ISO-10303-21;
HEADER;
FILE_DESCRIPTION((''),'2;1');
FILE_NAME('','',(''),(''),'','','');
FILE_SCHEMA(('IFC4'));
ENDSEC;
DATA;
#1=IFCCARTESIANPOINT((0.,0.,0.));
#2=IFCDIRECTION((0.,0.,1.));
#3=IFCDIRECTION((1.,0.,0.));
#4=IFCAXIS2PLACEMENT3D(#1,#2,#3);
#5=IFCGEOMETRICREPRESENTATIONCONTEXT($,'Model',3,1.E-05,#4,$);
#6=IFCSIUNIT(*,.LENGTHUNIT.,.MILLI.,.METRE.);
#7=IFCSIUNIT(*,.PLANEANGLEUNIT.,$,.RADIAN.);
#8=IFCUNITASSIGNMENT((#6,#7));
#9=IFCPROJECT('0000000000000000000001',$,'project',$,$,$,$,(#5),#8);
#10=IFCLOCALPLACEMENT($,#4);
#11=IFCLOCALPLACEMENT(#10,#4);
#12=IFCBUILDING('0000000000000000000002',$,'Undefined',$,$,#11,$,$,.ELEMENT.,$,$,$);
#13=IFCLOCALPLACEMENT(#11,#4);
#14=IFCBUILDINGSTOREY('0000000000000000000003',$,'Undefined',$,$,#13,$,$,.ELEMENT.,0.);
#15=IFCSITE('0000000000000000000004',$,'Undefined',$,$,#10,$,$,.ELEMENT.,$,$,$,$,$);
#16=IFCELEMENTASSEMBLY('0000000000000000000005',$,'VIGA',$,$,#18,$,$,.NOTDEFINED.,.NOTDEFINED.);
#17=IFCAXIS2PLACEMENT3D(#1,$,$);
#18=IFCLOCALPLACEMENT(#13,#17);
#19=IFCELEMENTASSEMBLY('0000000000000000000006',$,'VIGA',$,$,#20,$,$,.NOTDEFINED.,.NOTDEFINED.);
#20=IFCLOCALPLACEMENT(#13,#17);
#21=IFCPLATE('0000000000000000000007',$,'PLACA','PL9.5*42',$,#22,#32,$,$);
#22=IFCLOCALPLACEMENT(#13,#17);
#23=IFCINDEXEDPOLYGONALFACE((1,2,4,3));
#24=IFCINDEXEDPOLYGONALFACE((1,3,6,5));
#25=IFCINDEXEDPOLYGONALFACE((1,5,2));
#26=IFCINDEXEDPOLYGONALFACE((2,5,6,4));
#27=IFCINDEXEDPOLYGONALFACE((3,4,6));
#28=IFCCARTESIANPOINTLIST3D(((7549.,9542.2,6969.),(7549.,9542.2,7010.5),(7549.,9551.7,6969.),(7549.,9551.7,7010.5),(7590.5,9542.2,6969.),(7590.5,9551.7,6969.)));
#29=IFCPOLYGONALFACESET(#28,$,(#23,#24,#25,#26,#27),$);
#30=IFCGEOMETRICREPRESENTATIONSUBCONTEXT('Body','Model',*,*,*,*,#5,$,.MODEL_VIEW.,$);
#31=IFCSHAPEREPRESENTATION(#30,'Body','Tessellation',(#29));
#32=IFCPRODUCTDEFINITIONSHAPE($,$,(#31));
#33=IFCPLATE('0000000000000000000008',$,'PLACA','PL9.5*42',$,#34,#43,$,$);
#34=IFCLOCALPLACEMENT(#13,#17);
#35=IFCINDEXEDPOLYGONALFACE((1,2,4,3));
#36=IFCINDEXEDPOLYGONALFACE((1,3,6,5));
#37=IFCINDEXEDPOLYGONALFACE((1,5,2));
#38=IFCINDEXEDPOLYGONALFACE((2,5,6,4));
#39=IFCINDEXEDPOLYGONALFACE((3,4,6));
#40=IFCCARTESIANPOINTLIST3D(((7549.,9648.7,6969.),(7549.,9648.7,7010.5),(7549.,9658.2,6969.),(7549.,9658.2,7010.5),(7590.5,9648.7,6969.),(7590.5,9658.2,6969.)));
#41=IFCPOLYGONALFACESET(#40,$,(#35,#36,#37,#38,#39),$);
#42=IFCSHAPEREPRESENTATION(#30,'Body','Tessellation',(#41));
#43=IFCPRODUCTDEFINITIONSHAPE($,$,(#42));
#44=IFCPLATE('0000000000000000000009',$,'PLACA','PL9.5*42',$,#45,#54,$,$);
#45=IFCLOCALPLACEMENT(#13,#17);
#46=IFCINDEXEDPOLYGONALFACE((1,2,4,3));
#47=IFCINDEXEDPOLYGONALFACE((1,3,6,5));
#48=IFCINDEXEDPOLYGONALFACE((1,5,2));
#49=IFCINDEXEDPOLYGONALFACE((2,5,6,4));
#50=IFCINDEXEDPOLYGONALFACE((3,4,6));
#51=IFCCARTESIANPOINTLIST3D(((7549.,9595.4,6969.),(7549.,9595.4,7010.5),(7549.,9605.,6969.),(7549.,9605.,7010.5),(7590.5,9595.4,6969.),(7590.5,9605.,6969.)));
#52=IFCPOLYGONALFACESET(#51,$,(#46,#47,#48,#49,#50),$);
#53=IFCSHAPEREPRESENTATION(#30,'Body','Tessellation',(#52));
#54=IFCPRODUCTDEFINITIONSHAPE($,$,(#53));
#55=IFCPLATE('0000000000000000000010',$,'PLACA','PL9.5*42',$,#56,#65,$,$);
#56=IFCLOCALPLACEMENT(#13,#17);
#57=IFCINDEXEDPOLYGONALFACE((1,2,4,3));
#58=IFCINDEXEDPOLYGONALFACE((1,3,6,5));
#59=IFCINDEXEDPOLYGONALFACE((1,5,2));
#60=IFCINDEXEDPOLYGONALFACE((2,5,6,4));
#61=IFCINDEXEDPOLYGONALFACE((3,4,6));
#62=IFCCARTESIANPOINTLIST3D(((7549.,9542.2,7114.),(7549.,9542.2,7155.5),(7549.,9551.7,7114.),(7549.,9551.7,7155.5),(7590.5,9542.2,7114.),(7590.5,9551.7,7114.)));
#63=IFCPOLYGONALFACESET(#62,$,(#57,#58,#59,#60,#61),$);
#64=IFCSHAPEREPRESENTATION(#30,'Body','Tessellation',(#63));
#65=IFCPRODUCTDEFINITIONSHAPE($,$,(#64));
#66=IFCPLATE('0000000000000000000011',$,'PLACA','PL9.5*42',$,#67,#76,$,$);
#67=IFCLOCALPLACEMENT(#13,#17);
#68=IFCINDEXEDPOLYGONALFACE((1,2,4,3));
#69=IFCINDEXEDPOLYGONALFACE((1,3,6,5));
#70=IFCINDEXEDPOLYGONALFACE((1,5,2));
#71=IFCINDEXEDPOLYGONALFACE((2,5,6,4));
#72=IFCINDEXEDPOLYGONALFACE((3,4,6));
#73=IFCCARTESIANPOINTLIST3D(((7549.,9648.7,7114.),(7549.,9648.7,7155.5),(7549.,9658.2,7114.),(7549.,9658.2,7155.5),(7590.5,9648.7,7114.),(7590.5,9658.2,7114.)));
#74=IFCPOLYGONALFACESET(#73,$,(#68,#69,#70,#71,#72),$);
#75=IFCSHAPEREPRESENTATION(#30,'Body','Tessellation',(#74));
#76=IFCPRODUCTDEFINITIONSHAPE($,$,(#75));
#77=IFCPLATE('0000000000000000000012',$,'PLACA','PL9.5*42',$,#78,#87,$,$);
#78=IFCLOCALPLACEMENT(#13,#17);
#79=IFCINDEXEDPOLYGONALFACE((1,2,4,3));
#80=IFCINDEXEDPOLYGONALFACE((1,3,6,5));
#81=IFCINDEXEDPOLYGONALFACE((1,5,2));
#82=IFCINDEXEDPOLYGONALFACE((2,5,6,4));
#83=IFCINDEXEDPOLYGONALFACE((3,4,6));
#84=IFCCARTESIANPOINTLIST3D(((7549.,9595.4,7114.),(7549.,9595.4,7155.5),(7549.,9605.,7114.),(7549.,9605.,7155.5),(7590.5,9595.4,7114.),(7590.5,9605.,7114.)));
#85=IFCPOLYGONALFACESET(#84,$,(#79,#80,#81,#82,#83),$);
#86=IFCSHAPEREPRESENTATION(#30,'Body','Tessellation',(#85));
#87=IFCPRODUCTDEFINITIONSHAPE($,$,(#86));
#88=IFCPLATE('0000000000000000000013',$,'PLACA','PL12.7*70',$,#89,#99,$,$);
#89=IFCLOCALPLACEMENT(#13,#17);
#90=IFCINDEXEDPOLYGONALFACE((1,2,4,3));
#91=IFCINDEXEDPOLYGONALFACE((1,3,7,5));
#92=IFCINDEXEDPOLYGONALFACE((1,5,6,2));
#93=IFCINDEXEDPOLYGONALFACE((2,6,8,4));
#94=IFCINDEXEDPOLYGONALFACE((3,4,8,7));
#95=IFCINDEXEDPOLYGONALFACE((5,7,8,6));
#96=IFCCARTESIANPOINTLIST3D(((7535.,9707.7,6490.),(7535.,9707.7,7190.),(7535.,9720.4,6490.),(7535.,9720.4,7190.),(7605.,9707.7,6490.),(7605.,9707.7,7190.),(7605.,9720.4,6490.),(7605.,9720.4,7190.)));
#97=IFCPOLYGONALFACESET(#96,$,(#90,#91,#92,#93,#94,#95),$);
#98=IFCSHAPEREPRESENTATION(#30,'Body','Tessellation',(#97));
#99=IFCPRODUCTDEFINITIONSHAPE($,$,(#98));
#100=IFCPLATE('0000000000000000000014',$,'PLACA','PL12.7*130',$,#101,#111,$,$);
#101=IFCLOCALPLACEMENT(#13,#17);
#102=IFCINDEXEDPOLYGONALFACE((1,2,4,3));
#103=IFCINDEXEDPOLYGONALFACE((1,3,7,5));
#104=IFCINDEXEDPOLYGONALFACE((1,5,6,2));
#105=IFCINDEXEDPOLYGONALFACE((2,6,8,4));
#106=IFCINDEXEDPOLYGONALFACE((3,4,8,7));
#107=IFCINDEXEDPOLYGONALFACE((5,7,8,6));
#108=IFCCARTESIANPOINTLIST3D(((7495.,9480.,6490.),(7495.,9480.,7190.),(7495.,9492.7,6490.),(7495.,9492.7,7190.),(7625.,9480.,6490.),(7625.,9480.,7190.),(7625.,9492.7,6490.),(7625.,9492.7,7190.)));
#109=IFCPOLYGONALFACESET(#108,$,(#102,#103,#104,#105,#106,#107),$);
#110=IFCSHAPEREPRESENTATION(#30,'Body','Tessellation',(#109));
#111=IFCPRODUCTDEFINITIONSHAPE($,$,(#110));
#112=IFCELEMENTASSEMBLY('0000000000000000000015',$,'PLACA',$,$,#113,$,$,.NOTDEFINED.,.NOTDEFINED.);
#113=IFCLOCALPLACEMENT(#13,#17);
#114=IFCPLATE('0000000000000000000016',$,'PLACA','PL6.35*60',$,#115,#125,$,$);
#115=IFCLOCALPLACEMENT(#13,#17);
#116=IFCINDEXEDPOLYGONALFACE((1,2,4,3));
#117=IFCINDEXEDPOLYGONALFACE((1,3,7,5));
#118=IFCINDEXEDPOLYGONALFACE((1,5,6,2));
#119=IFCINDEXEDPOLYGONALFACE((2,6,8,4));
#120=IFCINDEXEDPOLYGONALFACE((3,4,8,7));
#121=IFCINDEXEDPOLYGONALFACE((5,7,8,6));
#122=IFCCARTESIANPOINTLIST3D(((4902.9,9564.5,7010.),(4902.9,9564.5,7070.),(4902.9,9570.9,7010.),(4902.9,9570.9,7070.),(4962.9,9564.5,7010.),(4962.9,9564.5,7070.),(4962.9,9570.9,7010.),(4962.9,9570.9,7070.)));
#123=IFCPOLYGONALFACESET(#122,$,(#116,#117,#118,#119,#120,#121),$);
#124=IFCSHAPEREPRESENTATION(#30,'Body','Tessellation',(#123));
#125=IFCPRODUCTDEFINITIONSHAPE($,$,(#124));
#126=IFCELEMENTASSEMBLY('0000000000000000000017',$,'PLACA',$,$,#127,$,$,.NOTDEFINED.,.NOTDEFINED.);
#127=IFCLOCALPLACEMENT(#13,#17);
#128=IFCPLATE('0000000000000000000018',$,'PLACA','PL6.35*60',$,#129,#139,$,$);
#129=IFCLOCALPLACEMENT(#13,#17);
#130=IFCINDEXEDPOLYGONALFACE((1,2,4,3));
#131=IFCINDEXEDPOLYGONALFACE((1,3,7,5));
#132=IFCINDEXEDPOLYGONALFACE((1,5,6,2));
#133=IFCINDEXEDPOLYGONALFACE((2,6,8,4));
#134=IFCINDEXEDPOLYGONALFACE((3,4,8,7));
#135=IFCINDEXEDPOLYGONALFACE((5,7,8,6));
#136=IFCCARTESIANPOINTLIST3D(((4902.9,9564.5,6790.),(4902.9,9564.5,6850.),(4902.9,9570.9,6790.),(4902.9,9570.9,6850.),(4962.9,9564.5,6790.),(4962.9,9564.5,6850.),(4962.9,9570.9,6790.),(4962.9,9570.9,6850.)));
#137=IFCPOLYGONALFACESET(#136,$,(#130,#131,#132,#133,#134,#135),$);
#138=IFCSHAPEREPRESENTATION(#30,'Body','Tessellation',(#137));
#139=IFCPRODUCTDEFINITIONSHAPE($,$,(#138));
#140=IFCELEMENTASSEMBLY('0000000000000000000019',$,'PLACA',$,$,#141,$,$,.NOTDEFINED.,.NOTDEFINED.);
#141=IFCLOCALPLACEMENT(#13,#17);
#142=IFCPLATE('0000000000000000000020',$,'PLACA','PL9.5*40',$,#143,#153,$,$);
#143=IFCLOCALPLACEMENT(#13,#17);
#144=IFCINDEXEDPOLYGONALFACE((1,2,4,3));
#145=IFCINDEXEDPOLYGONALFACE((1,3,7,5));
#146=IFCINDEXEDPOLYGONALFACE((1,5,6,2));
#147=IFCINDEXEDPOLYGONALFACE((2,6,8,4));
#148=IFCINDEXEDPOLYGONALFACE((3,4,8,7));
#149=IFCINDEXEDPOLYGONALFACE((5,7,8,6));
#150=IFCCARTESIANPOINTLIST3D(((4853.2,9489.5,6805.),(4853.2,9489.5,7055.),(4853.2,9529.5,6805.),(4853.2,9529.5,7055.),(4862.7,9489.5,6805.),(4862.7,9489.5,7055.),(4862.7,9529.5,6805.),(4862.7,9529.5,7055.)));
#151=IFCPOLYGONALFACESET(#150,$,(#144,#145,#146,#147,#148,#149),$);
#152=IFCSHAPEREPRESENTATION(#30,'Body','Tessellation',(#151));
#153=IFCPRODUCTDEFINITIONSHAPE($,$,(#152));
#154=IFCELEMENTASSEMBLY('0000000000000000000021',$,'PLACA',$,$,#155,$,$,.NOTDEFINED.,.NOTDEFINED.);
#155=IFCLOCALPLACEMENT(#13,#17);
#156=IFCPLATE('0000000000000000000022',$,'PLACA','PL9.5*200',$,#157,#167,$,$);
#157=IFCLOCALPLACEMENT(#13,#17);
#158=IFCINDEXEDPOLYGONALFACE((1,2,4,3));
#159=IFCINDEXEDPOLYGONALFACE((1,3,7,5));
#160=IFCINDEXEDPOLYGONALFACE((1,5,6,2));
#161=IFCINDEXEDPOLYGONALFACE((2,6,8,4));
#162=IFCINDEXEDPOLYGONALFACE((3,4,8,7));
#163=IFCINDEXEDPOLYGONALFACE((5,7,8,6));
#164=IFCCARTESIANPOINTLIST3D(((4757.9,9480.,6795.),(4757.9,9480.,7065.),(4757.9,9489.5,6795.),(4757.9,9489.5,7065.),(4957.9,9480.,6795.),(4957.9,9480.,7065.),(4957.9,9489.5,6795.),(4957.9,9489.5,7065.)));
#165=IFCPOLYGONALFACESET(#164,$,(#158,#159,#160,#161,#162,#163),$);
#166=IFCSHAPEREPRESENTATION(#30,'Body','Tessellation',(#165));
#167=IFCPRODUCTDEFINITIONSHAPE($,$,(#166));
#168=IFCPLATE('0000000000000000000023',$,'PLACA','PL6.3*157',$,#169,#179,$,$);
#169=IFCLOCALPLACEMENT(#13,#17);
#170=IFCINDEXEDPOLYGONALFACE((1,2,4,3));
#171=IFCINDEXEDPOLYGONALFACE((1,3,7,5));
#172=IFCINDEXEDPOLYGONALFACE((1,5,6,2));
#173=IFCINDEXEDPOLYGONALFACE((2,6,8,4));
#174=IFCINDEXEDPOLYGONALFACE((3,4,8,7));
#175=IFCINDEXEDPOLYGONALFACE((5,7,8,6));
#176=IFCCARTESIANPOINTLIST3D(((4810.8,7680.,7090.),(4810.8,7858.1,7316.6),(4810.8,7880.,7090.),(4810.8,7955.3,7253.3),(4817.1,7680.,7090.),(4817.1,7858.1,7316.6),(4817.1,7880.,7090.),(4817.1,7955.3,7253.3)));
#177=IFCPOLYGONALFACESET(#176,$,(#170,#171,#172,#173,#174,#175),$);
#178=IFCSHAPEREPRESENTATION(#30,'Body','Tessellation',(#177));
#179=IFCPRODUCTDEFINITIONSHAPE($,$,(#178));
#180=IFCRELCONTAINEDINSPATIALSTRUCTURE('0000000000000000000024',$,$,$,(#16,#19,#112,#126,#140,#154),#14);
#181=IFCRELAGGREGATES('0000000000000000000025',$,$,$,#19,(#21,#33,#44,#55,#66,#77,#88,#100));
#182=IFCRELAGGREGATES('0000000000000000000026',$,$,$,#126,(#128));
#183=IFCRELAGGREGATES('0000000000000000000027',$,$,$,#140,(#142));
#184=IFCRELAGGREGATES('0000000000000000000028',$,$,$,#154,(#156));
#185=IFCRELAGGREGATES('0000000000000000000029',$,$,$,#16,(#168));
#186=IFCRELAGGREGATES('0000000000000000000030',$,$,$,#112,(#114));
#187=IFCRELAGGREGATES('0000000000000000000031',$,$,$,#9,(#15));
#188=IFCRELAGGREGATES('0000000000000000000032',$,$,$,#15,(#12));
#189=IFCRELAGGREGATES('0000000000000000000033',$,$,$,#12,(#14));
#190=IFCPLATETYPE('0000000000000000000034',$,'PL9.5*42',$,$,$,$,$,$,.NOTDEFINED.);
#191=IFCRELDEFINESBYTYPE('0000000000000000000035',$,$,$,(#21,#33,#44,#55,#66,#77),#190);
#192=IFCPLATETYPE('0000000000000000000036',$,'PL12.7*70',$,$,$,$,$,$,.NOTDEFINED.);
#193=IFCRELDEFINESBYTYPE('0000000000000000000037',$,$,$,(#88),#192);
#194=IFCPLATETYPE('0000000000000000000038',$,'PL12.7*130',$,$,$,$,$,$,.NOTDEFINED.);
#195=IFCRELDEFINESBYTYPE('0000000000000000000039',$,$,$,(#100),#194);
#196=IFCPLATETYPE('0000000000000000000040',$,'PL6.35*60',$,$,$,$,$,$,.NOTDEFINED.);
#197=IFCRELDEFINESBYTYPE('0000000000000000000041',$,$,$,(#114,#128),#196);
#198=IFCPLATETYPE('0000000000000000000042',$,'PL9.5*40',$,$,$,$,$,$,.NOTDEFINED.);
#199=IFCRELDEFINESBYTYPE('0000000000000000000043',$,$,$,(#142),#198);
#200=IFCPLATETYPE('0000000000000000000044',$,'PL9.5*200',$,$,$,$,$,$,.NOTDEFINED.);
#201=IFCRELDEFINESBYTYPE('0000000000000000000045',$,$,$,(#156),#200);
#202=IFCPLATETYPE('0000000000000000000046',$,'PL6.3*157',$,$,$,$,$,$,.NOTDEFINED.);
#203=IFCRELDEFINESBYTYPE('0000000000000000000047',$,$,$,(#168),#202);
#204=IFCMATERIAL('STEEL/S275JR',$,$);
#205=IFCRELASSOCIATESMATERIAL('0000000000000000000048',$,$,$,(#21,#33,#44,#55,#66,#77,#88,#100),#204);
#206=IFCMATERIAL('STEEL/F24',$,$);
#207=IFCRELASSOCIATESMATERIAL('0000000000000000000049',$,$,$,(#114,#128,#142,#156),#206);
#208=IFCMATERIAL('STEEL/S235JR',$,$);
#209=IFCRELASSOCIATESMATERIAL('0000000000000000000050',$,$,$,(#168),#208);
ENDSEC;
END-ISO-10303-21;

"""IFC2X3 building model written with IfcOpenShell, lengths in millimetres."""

from ifc_helpers import new_model, si_unit, frame, origin_with_axes, place, context, subcontext, project, spatial, polyline, outline, extrude, material, type_object, element, aggregate, save


model = new_model("IFC2X3")

# Units and contexts
model_context = context("Model", 3, precision=1e-05, world=origin_with_axes())
body_context = subcontext(model_context, "Body", "Model", "MODEL_VIEW")
ifc_project = project(units=[si_unit("LENGTHUNIT", "METRE", prefix="MILLI"), si_unit("PLANEANGLEUNIT", "RADIAN")], contexts=[model_context])

# Site, building, storey
site_placement = place(None, origin_with_axes())
site = spatial("IfcSite", under=ifc_project, at=site_placement, Name="Undefined", CompositionType="ELEMENT")
building_placement = place(site_placement, origin_with_axes())
building = spatial("IfcBuilding", under=site, at=building_placement, Name="Undefined", CompositionType="ELEMENT")
storey_placement = place(building_placement, origin_with_axes())
storey = spatial("IfcBuildingStorey", under=building, at=storey_placement, Name="Undefined", CompositionType="ELEMENT", Elevation=0.0)

# Shared definitions
ifc_material_1 = material(Name="STEEL/S275JR")

# Shared definitions
ifc_material_2 = material(Name="STEEL/S235JR")

# Element assemblies, plates
assembly_1_placement = place(storey_placement, origin_with_axes())
assembly_1 = element("IfcElementAssembly", 1, at=assembly_1_placement, inside=storey, Name="VIGA", AssemblyPlace="NOTDEFINED", PredefinedType="NOTDEFINED")
assembly_2_placement = place(storey_placement, origin_with_axes())
assembly_2 = element("IfcElementAssembly", 2, at=assembly_2_placement, inside=storey, Name="VIGA", AssemblyPlace="NOTDEFINED", PredefinedType="NOTDEFINED")
plate_type_1 = type_object("IfcPlateType", Name="PL9.5*42", PredefinedType="NOTDEFINED")
plate_1_placement = place(assembly_2_placement, frame((7549.0, 9547.0, 6969.0), z_axis=(0.0, 1.0, 0.0), x_axis=(0.0, 0.0, 1.0)))
plate_1 = element("IfcPlate", 3, at=plate_1_placement, type_object=plate_type_1, material=ifc_material_1, Name="PLACA", Description="PL9.5*42", context=body_context, shape_type="SweptSolid", body=[
    extrude(outline(polyline([(0.0, 0.0), (41.5, 0.0), (0.0, 41.5), (0.0, 0.0)])), frame((0.0, 0.0, -4.7), z_axis=(0.0, 0.0, 1.0), x_axis=(1.0, 0.0, 0.0)), (0.0, 0.0, 1.0), 9.5),
])
plate_2_placement = place(assembly_2_placement, frame((7549.0, 9653.5, 6969.0), z_axis=(0.0, 1.0, 0.0), x_axis=(0.0, 0.0, 1.0)))
plate_2 = element("IfcPlate", 4, at=plate_2_placement, type_object=plate_type_1, material=ifc_material_1, Name="PLACA", Description="PL9.5*42", context=body_context, shape_type="SweptSolid", body=[
    extrude(outline(polyline([(0.0, 0.0), (41.5, 0.0), (0.0, 41.5), (0.0, 0.0)])), frame((0.0, 0.0, -4.7), z_axis=(0.0, 0.0, 1.0), x_axis=(1.0, 0.0, 0.0)), (0.0, 0.0, 1.0), 9.5),
])
plate_3_placement = place(assembly_2_placement, frame((7549.0, 9600.2, 6969.0), z_axis=(0.0, 1.0, 0.0), x_axis=(0.0, 0.0, 1.0)))
plate_3 = element("IfcPlate", 5, at=plate_3_placement, type_object=plate_type_1, material=ifc_material_1, Name="PLACA", Description="PL9.5*42", context=body_context, shape_type="SweptSolid", body=[
    extrude(outline(polyline([(0.0, 0.0), (41.5, 0.0), (0.0, 41.5), (0.0, 0.0)])), frame((0.0, 0.0, -4.7), z_axis=(0.0, 0.0, 1.0), x_axis=(1.0, 0.0, 0.0)), (0.0, 0.0, 1.0), 9.5),
])
plate_4_placement = place(assembly_2_placement, frame((7549.0, 9547.0, 7114.0), z_axis=(0.0, 1.0, 0.0), x_axis=(0.0, 0.0, 1.0)))
plate_4 = element("IfcPlate", 6, at=plate_4_placement, type_object=plate_type_1, material=ifc_material_1, Name="PLACA", Description="PL9.5*42", context=body_context, shape_type="SweptSolid", body=[
    extrude(outline(polyline([(0.0, 0.0), (41.5, 0.0), (0.0, 41.5), (0.0, 0.0)])), frame((0.0, 0.0, -4.7), z_axis=(0.0, 0.0, 1.0), x_axis=(1.0, 0.0, 0.0)), (0.0, 0.0, 1.0), 9.5),
])
plate_5_placement = place(assembly_2_placement, frame((7549.0, 9653.5, 7114.0), z_axis=(0.0, 1.0, 0.0), x_axis=(0.0, 0.0, 1.0)))
plate_5 = element("IfcPlate", 7, at=plate_5_placement, type_object=plate_type_1, material=ifc_material_1, Name="PLACA", Description="PL9.5*42", context=body_context, shape_type="SweptSolid", body=[
    extrude(outline(polyline([(0.0, 0.0), (41.5, 0.0), (0.0, 41.5), (0.0, 0.0)])), frame((0.0, 0.0, -4.7), z_axis=(0.0, 0.0, 1.0), x_axis=(1.0, 0.0, 0.0)), (0.0, 0.0, 1.0), 9.5),
])
plate_6_placement = place(assembly_2_placement, frame((7549.0, 9600.2, 7114.0), z_axis=(0.0, 1.0, 0.0), x_axis=(0.0, 0.0, 1.0)))
plate_6 = element("IfcPlate", 8, at=plate_6_placement, type_object=plate_type_1, material=ifc_material_1, Name="PLACA", Description="PL9.5*42", context=body_context, shape_type="SweptSolid", body=[
    extrude(outline(polyline([(0.0, 0.0), (41.5, 0.0), (0.0, 41.5), (0.0, 0.0)])), frame((0.0, 0.0, -4.7), z_axis=(0.0, 0.0, 1.0), x_axis=(1.0, 0.0, 0.0)), (0.0, 0.0, 1.0), 9.5),
])
plate_type_2 = type_object("IfcPlateType", Name="PL12.7*70", PredefinedType="NOTDEFINED")
plate_7_placement = place(assembly_2_placement, frame((7535.0, 9714.0, 7190.0), z_axis=(0.0, 1.0, 0.0), x_axis=(1.0, 0.0, 0.0)))
plate_7 = element("IfcPlate", 9, at=plate_7_placement, type_object=plate_type_2, material=ifc_material_1, Name="PLACA", Description="PL12.7*70", context=body_context, shape_type="SweptSolid", body=[
    extrude(outline(polyline([(0.0, 0.0), (70.0, 0.0), (70.0, 700.0), (0.0, 700.0), (0.0, 0.0)])), frame((0.0, 0.0, -6.3), z_axis=(0.0, 0.0, 1.0), x_axis=(1.0, 0.0, 0.0)), (0.0, 0.0, 1.0), 12.7),
])
plate_type_3 = type_object("IfcPlateType", Name="PL12.7*130", PredefinedType="NOTDEFINED")
plate_8_placement = place(assembly_2_placement, frame((7495.0, 9486.3, 7190.0), z_axis=(0.0, 1.0, 0.0), x_axis=(1.0, 0.0, 0.0)))
plate_8 = element("IfcPlate", 10, at=plate_8_placement, type_object=plate_type_3, material=ifc_material_1, Name="PLACA", Description="PL12.7*130", context=body_context, shape_type="SweptSolid", body=[
    extrude(outline(polyline([(0.0, 0.0), (130.0, 0.0), (130.0, 700.0), (0.0, 700.0), (0.0, 0.0)])), frame((0.0, 0.0, -6.3), z_axis=(0.0, 0.0, 1.0), x_axis=(1.0, 0.0, 0.0)), (0.0, 0.0, 1.0), 12.7),
])
aggregate(assembly_2, [plate_1, plate_2, plate_3, plate_4, plate_5, plate_6, plate_7, plate_8])

# Element assemblies, plates
assembly_3_placement = place(storey_placement, origin_with_axes())
assembly_3 = element("IfcElementAssembly", 11, at=assembly_3_placement, inside=storey, Name="PLACA", AssemblyPlace="NOTDEFINED", PredefinedType="NOTDEFINED")
ifc_material_3 = material(Name="STEEL/F24")
plate_type_4 = type_object("IfcPlateType", Name="PL6.35*60", PredefinedType="NOTDEFINED")
plate_9_placement = place(assembly_3_placement, frame((4902.9, 9567.7, 7070.0), z_axis=(0.0, 1.0, 0.0), x_axis=(1.0, 0.0, 0.0)))
plate_9 = element("IfcPlate", 12, at=plate_9_placement, type_object=plate_type_4, material=ifc_material_3, Name="PLACA", Description="PL6.35*60", context=body_context, shape_type="SweptSolid", body=[
    extrude(outline(polyline([(0.0, 0.0), (60.0, 0.0), (60.0, 60.0), (0.0, 60.0), (0.0, 0.0)])), frame((0.0, 0.0, -3.2), z_axis=(0.0, 0.0, 1.0), x_axis=(1.0, 0.0, 0.0)), (0.0, 0.0, 1.0), 6.4),
])
assembly_4_placement = place(storey_placement, origin_with_axes())
assembly_4 = element("IfcElementAssembly", 13, at=assembly_4_placement, inside=storey, Name="PLACA", AssemblyPlace="NOTDEFINED", PredefinedType="NOTDEFINED")
plate_10_placement = place(assembly_4_placement, frame((4902.9, 9567.7, 6850.0), z_axis=(0.0, 1.0, 0.0), x_axis=(1.0, 0.0, 0.0)))
plate_10 = element("IfcPlate", 14, at=plate_10_placement, type_object=plate_type_4, material=ifc_material_3, Name="PLACA", Description="PL6.35*60", context=body_context, shape_type="SweptSolid", body=[
    extrude(outline(polyline([(0.0, 0.0), (60.0, 0.0), (60.0, 60.0), (0.0, 60.0), (0.0, 0.0)])), frame((0.0, 0.0, -3.2), z_axis=(0.0, 0.0, 1.0), x_axis=(1.0, 0.0, 0.0)), (0.0, 0.0, 1.0), 6.4),
])
aggregate(assembly_4, [plate_10])
assembly_5_placement = place(storey_placement, origin_with_axes())
assembly_5 = element("IfcElementAssembly", 15, at=assembly_5_placement, inside=storey, Name="PLACA", AssemblyPlace="NOTDEFINED", PredefinedType="NOTDEFINED")
plate_type_5 = type_object("IfcPlateType", Name="PL9.5*40", PredefinedType="NOTDEFINED")
plate_11_placement = place(assembly_5_placement, frame((4857.9, 9489.5, 7055.0), z_axis=(1.0, 0.0, 0.0), x_axis=(0.0, 0.0, -1.0)))
plate_11 = element("IfcPlate", 16, at=plate_11_placement, type_object=plate_type_5, material=ifc_material_3, Name="PLACA", Description="PL9.5*40", context=body_context, shape_type="SweptSolid", body=[
    extrude(outline(polyline([(0.0, 0.0), (250.0, 0.0), (250.0, 40.0), (0.0, 40.0), (0.0, 0.0)])), frame((0.0, 0.0, -4.7), z_axis=(0.0, 0.0, 1.0), x_axis=(1.0, 0.0, 0.0)), (0.0, 0.0, 1.0), 9.5),
])
aggregate(assembly_5, [plate_11])
assembly_6_placement = place(storey_placement, origin_with_axes())
assembly_6 = element("IfcElementAssembly", 17, at=assembly_6_placement, inside=storey, Name="PLACA", AssemblyPlace="NOTDEFINED", PredefinedType="NOTDEFINED")
plate_type_6 = type_object("IfcPlateType", Name="PL9.5*200", PredefinedType="NOTDEFINED")
plate_12_placement = place(assembly_6_placement, frame((4757.9, 9484.8, 7065.0), z_axis=(0.0, 1.0, 0.0), x_axis=(1.0, 0.0, 0.0)))
plate_12 = element("IfcPlate", 18, at=plate_12_placement, type_object=plate_type_6, material=ifc_material_3, Name="PLACA", Description="PL9.5*200", context=body_context, shape_type="SweptSolid", body=[
    extrude(outline(polyline([(0.0, 0.0), (200.0, 0.0), (200.0, 270.0), (0.0, 270.0), (0.0, 0.0)])), frame((0.0, 0.0, -4.7), z_axis=(0.0, 0.0, 1.0), x_axis=(1.0, 0.0, 0.0)), (0.0, 0.0, 1.0), 9.5),
])
aggregate(assembly_6, [plate_12])

# Plate
plate_type_7 = type_object("IfcPlateType", Name="PL6.3*157", PredefinedType="NOTDEFINED")
plate_13_placement = place(assembly_1_placement, frame((4813.9, 7680.0, 7090.0), z_axis=(1.0, 0.0, 0.0), x_axis=(0.0, 1.0, 0.0)))
plate_13 = element("IfcPlate", 19, at=plate_13_placement, type_object=plate_type_7, material=ifc_material_2, Name="PLACA", Description="PL6.3*157", context=body_context, shape_type="SweptSolid", body=[
    extrude(outline(polyline([(0.0, 0.0), (200.0, 0.0), (275.3, 163.3), (178.1, 226.6), (0.0, 0.0)])), frame((0.0, 0.0, -3.1), z_axis=(0.0, 0.0, 1.0), x_axis=(1.0, 0.0, 0.0)), (0.0, 0.0, 1.0), 6.3),
])
aggregate(assembly_1, [plate_13])

aggregate(assembly_3, [plate_9])

save(model, "model.ifc")
